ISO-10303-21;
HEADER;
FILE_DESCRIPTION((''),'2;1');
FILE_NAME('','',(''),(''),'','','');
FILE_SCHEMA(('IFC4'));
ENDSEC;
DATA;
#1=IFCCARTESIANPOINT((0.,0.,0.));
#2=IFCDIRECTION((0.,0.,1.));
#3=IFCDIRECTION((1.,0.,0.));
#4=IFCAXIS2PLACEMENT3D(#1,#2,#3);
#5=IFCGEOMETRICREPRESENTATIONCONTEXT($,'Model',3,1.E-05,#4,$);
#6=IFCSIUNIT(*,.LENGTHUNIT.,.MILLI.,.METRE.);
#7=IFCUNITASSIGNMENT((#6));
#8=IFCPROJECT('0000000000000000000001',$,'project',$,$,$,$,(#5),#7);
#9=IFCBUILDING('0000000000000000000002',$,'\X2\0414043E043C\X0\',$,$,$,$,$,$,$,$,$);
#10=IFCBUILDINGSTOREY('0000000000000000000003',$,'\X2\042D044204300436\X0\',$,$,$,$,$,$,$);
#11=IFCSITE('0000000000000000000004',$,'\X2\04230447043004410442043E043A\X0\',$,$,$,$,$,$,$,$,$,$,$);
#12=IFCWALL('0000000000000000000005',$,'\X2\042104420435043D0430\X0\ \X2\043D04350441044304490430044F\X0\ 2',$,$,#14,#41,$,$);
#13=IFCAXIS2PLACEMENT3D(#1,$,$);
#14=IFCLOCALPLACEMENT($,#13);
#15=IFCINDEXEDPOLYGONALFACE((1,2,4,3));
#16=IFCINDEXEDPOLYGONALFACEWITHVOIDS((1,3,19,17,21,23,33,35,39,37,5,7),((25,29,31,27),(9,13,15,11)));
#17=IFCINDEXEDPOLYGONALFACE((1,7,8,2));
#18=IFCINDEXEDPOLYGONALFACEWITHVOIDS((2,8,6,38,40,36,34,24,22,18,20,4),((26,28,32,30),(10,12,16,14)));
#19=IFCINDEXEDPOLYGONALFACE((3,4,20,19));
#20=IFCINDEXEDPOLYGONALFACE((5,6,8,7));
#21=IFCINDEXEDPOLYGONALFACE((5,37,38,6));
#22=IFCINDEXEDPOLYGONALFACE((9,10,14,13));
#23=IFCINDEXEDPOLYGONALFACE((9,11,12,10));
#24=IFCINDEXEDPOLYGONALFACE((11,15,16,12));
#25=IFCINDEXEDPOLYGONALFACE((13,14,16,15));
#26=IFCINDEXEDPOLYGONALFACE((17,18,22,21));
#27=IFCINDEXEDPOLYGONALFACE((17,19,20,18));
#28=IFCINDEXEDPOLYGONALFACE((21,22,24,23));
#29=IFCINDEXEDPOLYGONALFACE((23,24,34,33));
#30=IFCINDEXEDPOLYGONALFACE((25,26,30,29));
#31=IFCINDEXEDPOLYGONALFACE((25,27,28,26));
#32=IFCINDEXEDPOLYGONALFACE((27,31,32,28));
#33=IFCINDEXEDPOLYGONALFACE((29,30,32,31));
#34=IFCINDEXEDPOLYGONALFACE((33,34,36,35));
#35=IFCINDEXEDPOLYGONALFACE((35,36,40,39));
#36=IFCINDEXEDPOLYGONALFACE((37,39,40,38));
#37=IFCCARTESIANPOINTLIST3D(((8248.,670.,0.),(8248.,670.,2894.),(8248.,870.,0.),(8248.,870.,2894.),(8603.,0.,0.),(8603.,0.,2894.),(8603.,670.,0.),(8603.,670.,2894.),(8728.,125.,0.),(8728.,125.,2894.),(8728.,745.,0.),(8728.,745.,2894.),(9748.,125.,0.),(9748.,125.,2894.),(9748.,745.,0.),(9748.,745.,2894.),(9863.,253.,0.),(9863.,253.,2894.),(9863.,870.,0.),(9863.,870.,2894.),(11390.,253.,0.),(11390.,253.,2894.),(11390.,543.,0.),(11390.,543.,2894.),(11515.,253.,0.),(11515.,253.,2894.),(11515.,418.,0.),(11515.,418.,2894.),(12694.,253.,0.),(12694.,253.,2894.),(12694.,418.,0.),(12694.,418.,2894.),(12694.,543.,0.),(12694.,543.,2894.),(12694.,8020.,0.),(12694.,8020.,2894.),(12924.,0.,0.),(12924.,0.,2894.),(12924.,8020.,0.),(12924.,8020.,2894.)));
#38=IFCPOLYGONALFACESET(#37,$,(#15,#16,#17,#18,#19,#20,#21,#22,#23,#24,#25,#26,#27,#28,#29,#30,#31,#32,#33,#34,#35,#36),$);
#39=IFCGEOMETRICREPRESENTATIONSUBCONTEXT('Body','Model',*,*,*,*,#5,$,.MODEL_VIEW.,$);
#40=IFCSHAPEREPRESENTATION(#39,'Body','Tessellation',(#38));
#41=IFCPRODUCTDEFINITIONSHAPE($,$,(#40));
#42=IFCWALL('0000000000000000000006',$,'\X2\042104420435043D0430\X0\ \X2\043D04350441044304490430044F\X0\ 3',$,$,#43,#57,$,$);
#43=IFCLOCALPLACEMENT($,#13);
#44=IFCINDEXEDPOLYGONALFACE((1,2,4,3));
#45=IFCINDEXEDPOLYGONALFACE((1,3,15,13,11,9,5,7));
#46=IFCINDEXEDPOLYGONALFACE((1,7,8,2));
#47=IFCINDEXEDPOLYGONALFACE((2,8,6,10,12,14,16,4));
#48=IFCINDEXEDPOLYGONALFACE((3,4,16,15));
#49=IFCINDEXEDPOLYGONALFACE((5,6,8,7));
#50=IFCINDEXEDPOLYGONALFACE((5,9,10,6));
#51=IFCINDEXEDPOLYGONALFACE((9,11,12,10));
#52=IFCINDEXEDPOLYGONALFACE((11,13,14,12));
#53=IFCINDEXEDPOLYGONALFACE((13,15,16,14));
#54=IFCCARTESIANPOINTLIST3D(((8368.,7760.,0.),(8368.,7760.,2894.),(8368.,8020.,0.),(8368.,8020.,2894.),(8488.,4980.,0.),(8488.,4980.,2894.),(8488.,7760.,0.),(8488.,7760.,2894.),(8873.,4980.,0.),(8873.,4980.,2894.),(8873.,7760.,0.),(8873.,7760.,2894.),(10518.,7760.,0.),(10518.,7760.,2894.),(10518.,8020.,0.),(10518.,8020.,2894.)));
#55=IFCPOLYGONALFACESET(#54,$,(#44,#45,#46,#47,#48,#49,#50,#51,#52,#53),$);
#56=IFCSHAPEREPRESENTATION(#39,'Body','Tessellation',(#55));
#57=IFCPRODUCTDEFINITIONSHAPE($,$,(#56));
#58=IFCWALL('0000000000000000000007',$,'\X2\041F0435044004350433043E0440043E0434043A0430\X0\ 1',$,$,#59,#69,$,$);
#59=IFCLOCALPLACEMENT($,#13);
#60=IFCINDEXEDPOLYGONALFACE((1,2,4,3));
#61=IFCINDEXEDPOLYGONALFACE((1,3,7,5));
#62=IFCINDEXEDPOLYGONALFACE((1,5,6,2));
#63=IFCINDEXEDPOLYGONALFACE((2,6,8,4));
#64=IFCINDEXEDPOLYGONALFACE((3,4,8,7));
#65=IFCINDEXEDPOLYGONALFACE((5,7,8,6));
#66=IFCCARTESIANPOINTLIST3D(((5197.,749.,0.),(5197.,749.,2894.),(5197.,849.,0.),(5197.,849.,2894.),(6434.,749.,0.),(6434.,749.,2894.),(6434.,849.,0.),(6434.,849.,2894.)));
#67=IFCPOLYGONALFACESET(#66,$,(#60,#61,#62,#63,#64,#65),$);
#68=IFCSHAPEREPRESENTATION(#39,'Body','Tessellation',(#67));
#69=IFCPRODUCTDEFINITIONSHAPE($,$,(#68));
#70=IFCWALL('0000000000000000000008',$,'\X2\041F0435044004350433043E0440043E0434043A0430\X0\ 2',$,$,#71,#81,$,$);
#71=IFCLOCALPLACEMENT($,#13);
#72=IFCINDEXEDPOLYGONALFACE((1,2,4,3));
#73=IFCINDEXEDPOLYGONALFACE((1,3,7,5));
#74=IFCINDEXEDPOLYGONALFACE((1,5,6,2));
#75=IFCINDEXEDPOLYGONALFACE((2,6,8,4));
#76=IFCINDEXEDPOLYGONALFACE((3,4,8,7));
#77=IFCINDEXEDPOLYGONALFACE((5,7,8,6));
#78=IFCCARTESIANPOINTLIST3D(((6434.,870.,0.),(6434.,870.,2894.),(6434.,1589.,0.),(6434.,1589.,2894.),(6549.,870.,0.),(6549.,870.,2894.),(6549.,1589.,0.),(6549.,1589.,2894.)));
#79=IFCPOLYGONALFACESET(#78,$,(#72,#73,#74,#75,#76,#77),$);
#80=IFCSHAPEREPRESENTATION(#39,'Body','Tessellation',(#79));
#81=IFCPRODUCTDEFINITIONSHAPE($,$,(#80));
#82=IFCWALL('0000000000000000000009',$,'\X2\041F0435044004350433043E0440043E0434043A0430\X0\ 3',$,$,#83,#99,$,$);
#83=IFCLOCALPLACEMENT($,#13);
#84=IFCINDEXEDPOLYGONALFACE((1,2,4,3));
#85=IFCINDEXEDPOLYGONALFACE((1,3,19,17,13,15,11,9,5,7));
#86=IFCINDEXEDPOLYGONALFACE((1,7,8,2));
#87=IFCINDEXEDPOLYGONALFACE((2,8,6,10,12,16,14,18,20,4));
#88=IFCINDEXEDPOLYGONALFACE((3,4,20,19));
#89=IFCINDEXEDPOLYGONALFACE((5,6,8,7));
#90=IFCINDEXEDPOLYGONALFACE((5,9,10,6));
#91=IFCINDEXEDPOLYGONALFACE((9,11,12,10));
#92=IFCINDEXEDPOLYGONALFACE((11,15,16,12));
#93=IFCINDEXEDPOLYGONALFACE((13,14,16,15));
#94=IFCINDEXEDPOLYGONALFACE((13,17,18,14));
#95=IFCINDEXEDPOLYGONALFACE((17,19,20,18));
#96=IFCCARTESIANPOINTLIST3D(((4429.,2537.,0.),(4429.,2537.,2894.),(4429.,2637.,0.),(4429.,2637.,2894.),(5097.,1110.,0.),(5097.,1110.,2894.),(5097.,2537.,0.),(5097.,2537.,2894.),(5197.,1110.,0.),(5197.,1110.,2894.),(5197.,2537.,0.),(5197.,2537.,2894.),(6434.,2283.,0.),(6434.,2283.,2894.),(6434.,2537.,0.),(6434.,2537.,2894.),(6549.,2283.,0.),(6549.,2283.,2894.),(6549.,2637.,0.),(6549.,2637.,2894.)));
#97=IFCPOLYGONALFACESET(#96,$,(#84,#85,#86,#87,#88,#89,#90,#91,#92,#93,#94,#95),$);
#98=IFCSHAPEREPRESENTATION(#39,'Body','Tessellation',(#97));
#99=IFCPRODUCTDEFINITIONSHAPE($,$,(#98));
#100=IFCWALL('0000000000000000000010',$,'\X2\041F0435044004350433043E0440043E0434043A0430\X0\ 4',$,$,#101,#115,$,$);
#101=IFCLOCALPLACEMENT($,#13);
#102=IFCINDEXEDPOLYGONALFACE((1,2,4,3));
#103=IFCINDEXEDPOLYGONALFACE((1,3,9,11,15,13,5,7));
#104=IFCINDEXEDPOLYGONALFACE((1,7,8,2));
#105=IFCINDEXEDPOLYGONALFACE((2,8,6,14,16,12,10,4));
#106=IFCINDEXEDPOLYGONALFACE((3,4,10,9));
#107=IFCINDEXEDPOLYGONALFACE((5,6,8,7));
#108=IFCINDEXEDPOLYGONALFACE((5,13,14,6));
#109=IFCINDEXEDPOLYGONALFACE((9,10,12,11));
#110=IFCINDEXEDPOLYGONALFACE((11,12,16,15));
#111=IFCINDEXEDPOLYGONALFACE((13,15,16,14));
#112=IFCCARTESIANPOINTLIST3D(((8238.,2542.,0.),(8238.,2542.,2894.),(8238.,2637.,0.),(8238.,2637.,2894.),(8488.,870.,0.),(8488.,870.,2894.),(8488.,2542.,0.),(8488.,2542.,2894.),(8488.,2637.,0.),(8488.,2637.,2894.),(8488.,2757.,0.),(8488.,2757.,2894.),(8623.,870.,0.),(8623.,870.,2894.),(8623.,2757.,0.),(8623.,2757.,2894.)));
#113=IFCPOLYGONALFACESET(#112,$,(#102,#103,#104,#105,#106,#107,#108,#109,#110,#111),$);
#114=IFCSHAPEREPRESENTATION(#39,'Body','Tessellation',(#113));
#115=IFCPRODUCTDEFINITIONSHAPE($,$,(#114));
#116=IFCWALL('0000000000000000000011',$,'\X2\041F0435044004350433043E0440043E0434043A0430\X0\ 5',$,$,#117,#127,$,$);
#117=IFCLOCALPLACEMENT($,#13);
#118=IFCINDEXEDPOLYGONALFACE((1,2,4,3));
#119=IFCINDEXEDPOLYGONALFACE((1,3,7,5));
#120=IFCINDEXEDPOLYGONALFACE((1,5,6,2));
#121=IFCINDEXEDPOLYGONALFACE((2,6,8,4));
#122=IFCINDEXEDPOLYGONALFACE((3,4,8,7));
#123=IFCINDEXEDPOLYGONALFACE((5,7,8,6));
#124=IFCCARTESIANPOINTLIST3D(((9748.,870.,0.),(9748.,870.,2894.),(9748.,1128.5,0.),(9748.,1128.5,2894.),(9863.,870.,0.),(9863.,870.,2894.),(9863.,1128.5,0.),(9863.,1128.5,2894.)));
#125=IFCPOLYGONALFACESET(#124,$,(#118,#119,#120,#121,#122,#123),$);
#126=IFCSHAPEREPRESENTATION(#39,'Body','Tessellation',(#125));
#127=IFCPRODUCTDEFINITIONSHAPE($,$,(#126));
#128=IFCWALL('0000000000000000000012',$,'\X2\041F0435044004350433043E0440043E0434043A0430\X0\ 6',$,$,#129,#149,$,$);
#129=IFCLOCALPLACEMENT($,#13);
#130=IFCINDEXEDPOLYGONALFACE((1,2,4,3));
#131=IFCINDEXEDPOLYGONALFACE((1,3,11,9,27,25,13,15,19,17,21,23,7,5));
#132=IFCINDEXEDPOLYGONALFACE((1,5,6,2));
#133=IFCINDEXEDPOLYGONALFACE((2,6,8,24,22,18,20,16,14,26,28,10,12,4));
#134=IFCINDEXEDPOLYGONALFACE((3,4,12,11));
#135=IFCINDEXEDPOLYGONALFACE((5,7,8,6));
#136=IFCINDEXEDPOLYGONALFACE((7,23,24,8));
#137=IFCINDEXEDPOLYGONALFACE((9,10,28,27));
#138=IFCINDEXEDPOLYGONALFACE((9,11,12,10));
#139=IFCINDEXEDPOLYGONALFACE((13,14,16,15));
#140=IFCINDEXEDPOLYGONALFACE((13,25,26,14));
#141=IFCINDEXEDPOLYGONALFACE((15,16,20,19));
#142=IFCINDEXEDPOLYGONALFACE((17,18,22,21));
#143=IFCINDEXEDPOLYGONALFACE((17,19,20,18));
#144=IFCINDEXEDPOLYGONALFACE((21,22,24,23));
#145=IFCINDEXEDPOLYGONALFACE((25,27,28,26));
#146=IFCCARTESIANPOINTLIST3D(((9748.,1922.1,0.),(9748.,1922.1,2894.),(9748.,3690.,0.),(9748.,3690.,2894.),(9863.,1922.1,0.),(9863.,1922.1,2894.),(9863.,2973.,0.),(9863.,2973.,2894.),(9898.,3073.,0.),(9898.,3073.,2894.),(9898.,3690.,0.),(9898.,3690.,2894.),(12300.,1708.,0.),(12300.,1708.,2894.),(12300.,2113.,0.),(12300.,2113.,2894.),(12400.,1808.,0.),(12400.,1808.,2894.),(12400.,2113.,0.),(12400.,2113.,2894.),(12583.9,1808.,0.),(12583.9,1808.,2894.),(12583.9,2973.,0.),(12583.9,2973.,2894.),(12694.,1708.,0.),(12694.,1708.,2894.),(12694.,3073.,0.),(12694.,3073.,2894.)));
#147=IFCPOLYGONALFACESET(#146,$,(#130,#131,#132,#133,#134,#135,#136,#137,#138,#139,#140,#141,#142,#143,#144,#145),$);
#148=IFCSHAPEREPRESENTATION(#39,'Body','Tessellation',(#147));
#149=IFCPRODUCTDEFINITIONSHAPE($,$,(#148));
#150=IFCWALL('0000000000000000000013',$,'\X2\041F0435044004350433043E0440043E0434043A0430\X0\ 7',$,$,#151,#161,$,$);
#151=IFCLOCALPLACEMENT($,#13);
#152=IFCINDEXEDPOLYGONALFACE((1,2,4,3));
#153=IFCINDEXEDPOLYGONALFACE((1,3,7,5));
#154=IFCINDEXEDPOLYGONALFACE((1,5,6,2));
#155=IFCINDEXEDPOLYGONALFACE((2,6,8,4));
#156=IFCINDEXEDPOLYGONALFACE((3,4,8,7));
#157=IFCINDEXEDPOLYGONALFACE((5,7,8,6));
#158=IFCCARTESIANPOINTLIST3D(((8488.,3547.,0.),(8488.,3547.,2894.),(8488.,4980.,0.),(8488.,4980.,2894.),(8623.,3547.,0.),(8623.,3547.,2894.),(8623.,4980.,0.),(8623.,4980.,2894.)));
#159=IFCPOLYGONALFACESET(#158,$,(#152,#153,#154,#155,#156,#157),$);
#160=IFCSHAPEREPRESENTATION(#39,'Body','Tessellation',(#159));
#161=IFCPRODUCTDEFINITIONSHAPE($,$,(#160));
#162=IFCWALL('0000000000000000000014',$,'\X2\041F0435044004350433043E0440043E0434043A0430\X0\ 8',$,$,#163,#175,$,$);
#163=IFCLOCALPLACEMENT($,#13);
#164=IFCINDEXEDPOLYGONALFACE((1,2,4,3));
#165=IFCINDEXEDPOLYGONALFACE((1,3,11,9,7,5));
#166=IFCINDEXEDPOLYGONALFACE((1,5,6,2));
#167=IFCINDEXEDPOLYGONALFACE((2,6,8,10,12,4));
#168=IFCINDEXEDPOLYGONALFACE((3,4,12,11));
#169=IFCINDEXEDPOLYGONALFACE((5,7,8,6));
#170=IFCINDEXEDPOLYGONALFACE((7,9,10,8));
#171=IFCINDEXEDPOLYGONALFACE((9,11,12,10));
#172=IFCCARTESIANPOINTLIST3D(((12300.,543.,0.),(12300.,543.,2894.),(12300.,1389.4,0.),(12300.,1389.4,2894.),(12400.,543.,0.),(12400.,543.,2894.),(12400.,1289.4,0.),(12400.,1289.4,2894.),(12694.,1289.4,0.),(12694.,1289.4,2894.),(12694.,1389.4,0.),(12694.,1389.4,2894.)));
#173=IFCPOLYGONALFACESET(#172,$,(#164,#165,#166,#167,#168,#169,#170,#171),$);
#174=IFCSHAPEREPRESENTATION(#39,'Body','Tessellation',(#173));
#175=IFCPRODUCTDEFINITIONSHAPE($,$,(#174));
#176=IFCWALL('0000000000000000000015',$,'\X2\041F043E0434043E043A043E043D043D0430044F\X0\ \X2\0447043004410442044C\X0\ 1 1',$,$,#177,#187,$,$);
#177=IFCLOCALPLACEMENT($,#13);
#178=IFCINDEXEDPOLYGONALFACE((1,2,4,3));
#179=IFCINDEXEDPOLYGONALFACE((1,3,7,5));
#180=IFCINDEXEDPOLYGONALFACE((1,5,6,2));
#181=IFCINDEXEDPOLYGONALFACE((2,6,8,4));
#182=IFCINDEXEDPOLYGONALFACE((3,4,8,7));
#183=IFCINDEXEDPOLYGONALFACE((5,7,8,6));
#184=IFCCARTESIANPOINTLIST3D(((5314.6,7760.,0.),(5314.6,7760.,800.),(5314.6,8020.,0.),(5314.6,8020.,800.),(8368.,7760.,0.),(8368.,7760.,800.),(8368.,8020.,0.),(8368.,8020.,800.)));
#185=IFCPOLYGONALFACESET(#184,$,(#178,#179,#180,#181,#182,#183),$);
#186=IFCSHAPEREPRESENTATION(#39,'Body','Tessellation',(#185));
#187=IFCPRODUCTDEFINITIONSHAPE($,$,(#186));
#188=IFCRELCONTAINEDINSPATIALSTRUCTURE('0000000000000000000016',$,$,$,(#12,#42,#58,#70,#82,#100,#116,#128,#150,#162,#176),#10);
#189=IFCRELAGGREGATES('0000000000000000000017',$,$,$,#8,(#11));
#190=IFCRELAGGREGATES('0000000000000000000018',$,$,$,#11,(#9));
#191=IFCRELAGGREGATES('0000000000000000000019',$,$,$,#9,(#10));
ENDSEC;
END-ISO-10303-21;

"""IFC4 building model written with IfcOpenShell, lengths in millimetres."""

from ifc_helpers import new_model, si_unit, origin, origin_with_axes, place, context, subcontext, project, spatial, polyline, outline, extrude, element, save


model = new_model("IFC4")

# Units and contexts
model_context = context("Model", 3, precision=1e-05, world=origin_with_axes())
body_context = subcontext(model_context, "Body", "Model", "MODEL_VIEW")
ifc_project = project(units=[si_unit("LENGTHUNIT", "METRE", prefix="MILLI")], contexts=[model_context])

# Site, building, storey
site = spatial("IfcSite", under=ifc_project, Name="Участок")
building = spatial("IfcBuilding", under=site, Name="Дом")
storey = spatial("IfcBuildingStorey", under=building, Name="Этаж")

# Walls
wall_1_placement = place(None, origin_with_axes())
element("IfcWall", 1, at=wall_1_placement, inside=storey, Name="Стена несущая 2", context=body_context, shape_type="SweptSolid", body=[
    extrude(outline(polyline([(8603.0, 0.0), (8603.0, 670.0), (8248.0, 670.0), (8248.0, 870.0), (9863.0, 870.0), (9863.0, 253.0), (11390.0, 253.0), (11390.0, 543.0), (12694.0, 543.0), (12694.0, 8020.0), (12924.0, 8020.0), (12924.0, 0.0), (8603.0, 0.0)]), holes=[polyline([(9748.0, 125.0), (9748.0, 745.0), (8728.0, 745.0), (8728.0, 125.0), (9748.0, 125.0)]), polyline([(11515.0, 418.0), (11515.0, 253.0), (12694.0, 253.0), (12694.0, 418.0), (11515.0, 418.0)])]), origin(), (0.0, 0.0, 1.0), 2894.0),
])
wall_2_placement = place(None, origin_with_axes())
element("IfcWall", 2, at=wall_2_placement, inside=storey, Name="Стена несущая 3", context=body_context, shape_type="SweptSolid", body=[
    extrude(outline(polyline([(8488.0, 7760.0), (8368.0, 7760.0), (8368.0, 8020.0), (10518.0, 8020.0), (10518.0, 7760.0), (8873.0, 7760.0), (8873.0, 4980.0), (8488.0, 4980.0), (8488.0, 7760.0)])), origin(), (0.0, 0.0, 1.0), 2894.0),
])
wall_3_placement = place(None, origin_with_axes())
element("IfcWall", 3, at=wall_3_placement, inside=storey, Name="Перегородка 1", context=body_context, shape_type="SweptSolid", body=[
    extrude(outline(polyline([(5197.0, 849.0), (6434.0, 849.0), (6434.0, 749.0), (5197.0, 749.0), (5197.0, 849.0)])), origin(), (0.0, 0.0, 1.0), 2894.0),
])
wall_4_placement = place(None, origin_with_axes())
element("IfcWall", 4, at=wall_4_placement, inside=storey, Name="Перегородка 2", context=body_context, shape_type="SweptSolid", body=[
    extrude(outline(polyline([(6434.0, 870.0), (6434.0, 2283.0), (6434.0, 1589.0), (6549.0, 1589.0), (6549.0, 870.0), (6434.0, 870.0)])), origin(), (0.0, 0.0, 1.0), 2894.0),
])
wall_5_placement = place(None, origin_with_axes())
element("IfcWall", 5, at=wall_5_placement, inside=storey, Name="Перегородка 3", context=body_context, shape_type="SweptSolid", body=[
    extrude(outline(polyline([(6434.0, 2537.0), (5197.0, 2537.0), (5197.0, 1110.0), (5097.0, 1110.0), (5097.0, 2537.0), (4429.0, 2537.0), (4429.0, 2637.0), (6549.0, 2637.0), (6549.0, 2283.0), (6434.0, 2283.0), (6434.0, 2537.0)])), origin(), (0.0, 0.0, 1.0), 2894.0),
])
wall_6_placement = place(None, origin_with_axes())
element("IfcWall", 6, at=wall_6_placement, inside=storey, Name="Перегородка 4", context=body_context, shape_type="SweptSolid", body=[
    extrude(outline(polyline([(8238.0, 2637.0), (8488.0, 2637.0), (8488.0, 2757.0), (8623.0, 2757.0), (8623.0, 870.0), (8488.0, 870.0), (8488.0, 2542.0), (8238.0, 2542.0), (8238.0, 2637.0)])), origin(), (0.0, 0.0, 1.0), 2894.0),
])
wall_7_placement = place(None, origin_with_axes())
element("IfcWall", 7, at=wall_7_placement, inside=storey, Name="Перегородка 5", context=body_context, shape_type="SweptSolid", body=[
    extrude(outline(polyline([(9863.0, 870.0), (9748.0, 870.0), (9748.0, 1128.5), (9863.0, 1128.5), (9863.0, 870.0)])), origin(), (0.0, 0.0, 1.0), 2894.0),
])
wall_8_placement = place(None, origin_with_axes())
element("IfcWall", 8, at=wall_8_placement, inside=storey, Name="Перегородка 6", context=body_context, shape_type="SweptSolid", body=[
    extrude(outline(polyline([(9748.0, 1922.1), (9748.0, 3690.0), (9898.0, 3690.0), (9898.0, 3073.0), (12694.0, 3073.0), (12694.0, 1708.0), (12300.0, 1708.0), (12300.0, 2113.0), (12400.0, 2113.0), (12400.0, 1808.0), (12583.9, 1808.0), (12583.9, 2973.0), (9863.0, 2973.0), (9863.0, 1922.1), (9748.0, 1922.1)])), origin(), (0.0, 0.0, 1.0), 2894.0),
])
wall_9_placement = place(None, origin_with_axes())
element("IfcWall", 9, at=wall_9_placement, inside=storey, Name="Перегородка 7", context=body_context, shape_type="SweptSolid", body=[
    extrude(outline(polyline([(8623.0, 4980.0), (8623.0, 3547.0), (8488.0, 3547.0), (8488.0, 4980.0), (8623.0, 4980.0)])), origin(), (0.0, 0.0, 1.0), 2894.0),
])
wall_10_placement = place(None, origin_with_axes())
element("IfcWall", 10, at=wall_10_placement, inside=storey, Name="Перегородка 8", context=body_context, shape_type="SweptSolid", body=[
    extrude(outline(polyline([(12300.0, 1389.4), (12694.0, 1389.4), (12694.0, 1289.4), (12400.0, 1289.4), (12400.0, 543.0), (12300.0, 543.0), (12300.0, 1389.4)])), origin(), (0.0, 0.0, 1.0), 2894.0),
])
wall_11_placement = place(None, origin_with_axes())
element("IfcWall", 11, at=wall_11_placement, inside=storey, Name="Подоконная часть 1 1", context=body_context, shape_type="SweptSolid", body=[
    extrude(outline(polyline([(5314.6, 7760.0), (5314.6, 8020.0), (8368.0, 8020.0), (8368.0, 7760.0), (5314.6, 7760.0)])), origin(), (0.0, 0.0, 1.0), 800.0),
])

save(model, "model.ifc")
